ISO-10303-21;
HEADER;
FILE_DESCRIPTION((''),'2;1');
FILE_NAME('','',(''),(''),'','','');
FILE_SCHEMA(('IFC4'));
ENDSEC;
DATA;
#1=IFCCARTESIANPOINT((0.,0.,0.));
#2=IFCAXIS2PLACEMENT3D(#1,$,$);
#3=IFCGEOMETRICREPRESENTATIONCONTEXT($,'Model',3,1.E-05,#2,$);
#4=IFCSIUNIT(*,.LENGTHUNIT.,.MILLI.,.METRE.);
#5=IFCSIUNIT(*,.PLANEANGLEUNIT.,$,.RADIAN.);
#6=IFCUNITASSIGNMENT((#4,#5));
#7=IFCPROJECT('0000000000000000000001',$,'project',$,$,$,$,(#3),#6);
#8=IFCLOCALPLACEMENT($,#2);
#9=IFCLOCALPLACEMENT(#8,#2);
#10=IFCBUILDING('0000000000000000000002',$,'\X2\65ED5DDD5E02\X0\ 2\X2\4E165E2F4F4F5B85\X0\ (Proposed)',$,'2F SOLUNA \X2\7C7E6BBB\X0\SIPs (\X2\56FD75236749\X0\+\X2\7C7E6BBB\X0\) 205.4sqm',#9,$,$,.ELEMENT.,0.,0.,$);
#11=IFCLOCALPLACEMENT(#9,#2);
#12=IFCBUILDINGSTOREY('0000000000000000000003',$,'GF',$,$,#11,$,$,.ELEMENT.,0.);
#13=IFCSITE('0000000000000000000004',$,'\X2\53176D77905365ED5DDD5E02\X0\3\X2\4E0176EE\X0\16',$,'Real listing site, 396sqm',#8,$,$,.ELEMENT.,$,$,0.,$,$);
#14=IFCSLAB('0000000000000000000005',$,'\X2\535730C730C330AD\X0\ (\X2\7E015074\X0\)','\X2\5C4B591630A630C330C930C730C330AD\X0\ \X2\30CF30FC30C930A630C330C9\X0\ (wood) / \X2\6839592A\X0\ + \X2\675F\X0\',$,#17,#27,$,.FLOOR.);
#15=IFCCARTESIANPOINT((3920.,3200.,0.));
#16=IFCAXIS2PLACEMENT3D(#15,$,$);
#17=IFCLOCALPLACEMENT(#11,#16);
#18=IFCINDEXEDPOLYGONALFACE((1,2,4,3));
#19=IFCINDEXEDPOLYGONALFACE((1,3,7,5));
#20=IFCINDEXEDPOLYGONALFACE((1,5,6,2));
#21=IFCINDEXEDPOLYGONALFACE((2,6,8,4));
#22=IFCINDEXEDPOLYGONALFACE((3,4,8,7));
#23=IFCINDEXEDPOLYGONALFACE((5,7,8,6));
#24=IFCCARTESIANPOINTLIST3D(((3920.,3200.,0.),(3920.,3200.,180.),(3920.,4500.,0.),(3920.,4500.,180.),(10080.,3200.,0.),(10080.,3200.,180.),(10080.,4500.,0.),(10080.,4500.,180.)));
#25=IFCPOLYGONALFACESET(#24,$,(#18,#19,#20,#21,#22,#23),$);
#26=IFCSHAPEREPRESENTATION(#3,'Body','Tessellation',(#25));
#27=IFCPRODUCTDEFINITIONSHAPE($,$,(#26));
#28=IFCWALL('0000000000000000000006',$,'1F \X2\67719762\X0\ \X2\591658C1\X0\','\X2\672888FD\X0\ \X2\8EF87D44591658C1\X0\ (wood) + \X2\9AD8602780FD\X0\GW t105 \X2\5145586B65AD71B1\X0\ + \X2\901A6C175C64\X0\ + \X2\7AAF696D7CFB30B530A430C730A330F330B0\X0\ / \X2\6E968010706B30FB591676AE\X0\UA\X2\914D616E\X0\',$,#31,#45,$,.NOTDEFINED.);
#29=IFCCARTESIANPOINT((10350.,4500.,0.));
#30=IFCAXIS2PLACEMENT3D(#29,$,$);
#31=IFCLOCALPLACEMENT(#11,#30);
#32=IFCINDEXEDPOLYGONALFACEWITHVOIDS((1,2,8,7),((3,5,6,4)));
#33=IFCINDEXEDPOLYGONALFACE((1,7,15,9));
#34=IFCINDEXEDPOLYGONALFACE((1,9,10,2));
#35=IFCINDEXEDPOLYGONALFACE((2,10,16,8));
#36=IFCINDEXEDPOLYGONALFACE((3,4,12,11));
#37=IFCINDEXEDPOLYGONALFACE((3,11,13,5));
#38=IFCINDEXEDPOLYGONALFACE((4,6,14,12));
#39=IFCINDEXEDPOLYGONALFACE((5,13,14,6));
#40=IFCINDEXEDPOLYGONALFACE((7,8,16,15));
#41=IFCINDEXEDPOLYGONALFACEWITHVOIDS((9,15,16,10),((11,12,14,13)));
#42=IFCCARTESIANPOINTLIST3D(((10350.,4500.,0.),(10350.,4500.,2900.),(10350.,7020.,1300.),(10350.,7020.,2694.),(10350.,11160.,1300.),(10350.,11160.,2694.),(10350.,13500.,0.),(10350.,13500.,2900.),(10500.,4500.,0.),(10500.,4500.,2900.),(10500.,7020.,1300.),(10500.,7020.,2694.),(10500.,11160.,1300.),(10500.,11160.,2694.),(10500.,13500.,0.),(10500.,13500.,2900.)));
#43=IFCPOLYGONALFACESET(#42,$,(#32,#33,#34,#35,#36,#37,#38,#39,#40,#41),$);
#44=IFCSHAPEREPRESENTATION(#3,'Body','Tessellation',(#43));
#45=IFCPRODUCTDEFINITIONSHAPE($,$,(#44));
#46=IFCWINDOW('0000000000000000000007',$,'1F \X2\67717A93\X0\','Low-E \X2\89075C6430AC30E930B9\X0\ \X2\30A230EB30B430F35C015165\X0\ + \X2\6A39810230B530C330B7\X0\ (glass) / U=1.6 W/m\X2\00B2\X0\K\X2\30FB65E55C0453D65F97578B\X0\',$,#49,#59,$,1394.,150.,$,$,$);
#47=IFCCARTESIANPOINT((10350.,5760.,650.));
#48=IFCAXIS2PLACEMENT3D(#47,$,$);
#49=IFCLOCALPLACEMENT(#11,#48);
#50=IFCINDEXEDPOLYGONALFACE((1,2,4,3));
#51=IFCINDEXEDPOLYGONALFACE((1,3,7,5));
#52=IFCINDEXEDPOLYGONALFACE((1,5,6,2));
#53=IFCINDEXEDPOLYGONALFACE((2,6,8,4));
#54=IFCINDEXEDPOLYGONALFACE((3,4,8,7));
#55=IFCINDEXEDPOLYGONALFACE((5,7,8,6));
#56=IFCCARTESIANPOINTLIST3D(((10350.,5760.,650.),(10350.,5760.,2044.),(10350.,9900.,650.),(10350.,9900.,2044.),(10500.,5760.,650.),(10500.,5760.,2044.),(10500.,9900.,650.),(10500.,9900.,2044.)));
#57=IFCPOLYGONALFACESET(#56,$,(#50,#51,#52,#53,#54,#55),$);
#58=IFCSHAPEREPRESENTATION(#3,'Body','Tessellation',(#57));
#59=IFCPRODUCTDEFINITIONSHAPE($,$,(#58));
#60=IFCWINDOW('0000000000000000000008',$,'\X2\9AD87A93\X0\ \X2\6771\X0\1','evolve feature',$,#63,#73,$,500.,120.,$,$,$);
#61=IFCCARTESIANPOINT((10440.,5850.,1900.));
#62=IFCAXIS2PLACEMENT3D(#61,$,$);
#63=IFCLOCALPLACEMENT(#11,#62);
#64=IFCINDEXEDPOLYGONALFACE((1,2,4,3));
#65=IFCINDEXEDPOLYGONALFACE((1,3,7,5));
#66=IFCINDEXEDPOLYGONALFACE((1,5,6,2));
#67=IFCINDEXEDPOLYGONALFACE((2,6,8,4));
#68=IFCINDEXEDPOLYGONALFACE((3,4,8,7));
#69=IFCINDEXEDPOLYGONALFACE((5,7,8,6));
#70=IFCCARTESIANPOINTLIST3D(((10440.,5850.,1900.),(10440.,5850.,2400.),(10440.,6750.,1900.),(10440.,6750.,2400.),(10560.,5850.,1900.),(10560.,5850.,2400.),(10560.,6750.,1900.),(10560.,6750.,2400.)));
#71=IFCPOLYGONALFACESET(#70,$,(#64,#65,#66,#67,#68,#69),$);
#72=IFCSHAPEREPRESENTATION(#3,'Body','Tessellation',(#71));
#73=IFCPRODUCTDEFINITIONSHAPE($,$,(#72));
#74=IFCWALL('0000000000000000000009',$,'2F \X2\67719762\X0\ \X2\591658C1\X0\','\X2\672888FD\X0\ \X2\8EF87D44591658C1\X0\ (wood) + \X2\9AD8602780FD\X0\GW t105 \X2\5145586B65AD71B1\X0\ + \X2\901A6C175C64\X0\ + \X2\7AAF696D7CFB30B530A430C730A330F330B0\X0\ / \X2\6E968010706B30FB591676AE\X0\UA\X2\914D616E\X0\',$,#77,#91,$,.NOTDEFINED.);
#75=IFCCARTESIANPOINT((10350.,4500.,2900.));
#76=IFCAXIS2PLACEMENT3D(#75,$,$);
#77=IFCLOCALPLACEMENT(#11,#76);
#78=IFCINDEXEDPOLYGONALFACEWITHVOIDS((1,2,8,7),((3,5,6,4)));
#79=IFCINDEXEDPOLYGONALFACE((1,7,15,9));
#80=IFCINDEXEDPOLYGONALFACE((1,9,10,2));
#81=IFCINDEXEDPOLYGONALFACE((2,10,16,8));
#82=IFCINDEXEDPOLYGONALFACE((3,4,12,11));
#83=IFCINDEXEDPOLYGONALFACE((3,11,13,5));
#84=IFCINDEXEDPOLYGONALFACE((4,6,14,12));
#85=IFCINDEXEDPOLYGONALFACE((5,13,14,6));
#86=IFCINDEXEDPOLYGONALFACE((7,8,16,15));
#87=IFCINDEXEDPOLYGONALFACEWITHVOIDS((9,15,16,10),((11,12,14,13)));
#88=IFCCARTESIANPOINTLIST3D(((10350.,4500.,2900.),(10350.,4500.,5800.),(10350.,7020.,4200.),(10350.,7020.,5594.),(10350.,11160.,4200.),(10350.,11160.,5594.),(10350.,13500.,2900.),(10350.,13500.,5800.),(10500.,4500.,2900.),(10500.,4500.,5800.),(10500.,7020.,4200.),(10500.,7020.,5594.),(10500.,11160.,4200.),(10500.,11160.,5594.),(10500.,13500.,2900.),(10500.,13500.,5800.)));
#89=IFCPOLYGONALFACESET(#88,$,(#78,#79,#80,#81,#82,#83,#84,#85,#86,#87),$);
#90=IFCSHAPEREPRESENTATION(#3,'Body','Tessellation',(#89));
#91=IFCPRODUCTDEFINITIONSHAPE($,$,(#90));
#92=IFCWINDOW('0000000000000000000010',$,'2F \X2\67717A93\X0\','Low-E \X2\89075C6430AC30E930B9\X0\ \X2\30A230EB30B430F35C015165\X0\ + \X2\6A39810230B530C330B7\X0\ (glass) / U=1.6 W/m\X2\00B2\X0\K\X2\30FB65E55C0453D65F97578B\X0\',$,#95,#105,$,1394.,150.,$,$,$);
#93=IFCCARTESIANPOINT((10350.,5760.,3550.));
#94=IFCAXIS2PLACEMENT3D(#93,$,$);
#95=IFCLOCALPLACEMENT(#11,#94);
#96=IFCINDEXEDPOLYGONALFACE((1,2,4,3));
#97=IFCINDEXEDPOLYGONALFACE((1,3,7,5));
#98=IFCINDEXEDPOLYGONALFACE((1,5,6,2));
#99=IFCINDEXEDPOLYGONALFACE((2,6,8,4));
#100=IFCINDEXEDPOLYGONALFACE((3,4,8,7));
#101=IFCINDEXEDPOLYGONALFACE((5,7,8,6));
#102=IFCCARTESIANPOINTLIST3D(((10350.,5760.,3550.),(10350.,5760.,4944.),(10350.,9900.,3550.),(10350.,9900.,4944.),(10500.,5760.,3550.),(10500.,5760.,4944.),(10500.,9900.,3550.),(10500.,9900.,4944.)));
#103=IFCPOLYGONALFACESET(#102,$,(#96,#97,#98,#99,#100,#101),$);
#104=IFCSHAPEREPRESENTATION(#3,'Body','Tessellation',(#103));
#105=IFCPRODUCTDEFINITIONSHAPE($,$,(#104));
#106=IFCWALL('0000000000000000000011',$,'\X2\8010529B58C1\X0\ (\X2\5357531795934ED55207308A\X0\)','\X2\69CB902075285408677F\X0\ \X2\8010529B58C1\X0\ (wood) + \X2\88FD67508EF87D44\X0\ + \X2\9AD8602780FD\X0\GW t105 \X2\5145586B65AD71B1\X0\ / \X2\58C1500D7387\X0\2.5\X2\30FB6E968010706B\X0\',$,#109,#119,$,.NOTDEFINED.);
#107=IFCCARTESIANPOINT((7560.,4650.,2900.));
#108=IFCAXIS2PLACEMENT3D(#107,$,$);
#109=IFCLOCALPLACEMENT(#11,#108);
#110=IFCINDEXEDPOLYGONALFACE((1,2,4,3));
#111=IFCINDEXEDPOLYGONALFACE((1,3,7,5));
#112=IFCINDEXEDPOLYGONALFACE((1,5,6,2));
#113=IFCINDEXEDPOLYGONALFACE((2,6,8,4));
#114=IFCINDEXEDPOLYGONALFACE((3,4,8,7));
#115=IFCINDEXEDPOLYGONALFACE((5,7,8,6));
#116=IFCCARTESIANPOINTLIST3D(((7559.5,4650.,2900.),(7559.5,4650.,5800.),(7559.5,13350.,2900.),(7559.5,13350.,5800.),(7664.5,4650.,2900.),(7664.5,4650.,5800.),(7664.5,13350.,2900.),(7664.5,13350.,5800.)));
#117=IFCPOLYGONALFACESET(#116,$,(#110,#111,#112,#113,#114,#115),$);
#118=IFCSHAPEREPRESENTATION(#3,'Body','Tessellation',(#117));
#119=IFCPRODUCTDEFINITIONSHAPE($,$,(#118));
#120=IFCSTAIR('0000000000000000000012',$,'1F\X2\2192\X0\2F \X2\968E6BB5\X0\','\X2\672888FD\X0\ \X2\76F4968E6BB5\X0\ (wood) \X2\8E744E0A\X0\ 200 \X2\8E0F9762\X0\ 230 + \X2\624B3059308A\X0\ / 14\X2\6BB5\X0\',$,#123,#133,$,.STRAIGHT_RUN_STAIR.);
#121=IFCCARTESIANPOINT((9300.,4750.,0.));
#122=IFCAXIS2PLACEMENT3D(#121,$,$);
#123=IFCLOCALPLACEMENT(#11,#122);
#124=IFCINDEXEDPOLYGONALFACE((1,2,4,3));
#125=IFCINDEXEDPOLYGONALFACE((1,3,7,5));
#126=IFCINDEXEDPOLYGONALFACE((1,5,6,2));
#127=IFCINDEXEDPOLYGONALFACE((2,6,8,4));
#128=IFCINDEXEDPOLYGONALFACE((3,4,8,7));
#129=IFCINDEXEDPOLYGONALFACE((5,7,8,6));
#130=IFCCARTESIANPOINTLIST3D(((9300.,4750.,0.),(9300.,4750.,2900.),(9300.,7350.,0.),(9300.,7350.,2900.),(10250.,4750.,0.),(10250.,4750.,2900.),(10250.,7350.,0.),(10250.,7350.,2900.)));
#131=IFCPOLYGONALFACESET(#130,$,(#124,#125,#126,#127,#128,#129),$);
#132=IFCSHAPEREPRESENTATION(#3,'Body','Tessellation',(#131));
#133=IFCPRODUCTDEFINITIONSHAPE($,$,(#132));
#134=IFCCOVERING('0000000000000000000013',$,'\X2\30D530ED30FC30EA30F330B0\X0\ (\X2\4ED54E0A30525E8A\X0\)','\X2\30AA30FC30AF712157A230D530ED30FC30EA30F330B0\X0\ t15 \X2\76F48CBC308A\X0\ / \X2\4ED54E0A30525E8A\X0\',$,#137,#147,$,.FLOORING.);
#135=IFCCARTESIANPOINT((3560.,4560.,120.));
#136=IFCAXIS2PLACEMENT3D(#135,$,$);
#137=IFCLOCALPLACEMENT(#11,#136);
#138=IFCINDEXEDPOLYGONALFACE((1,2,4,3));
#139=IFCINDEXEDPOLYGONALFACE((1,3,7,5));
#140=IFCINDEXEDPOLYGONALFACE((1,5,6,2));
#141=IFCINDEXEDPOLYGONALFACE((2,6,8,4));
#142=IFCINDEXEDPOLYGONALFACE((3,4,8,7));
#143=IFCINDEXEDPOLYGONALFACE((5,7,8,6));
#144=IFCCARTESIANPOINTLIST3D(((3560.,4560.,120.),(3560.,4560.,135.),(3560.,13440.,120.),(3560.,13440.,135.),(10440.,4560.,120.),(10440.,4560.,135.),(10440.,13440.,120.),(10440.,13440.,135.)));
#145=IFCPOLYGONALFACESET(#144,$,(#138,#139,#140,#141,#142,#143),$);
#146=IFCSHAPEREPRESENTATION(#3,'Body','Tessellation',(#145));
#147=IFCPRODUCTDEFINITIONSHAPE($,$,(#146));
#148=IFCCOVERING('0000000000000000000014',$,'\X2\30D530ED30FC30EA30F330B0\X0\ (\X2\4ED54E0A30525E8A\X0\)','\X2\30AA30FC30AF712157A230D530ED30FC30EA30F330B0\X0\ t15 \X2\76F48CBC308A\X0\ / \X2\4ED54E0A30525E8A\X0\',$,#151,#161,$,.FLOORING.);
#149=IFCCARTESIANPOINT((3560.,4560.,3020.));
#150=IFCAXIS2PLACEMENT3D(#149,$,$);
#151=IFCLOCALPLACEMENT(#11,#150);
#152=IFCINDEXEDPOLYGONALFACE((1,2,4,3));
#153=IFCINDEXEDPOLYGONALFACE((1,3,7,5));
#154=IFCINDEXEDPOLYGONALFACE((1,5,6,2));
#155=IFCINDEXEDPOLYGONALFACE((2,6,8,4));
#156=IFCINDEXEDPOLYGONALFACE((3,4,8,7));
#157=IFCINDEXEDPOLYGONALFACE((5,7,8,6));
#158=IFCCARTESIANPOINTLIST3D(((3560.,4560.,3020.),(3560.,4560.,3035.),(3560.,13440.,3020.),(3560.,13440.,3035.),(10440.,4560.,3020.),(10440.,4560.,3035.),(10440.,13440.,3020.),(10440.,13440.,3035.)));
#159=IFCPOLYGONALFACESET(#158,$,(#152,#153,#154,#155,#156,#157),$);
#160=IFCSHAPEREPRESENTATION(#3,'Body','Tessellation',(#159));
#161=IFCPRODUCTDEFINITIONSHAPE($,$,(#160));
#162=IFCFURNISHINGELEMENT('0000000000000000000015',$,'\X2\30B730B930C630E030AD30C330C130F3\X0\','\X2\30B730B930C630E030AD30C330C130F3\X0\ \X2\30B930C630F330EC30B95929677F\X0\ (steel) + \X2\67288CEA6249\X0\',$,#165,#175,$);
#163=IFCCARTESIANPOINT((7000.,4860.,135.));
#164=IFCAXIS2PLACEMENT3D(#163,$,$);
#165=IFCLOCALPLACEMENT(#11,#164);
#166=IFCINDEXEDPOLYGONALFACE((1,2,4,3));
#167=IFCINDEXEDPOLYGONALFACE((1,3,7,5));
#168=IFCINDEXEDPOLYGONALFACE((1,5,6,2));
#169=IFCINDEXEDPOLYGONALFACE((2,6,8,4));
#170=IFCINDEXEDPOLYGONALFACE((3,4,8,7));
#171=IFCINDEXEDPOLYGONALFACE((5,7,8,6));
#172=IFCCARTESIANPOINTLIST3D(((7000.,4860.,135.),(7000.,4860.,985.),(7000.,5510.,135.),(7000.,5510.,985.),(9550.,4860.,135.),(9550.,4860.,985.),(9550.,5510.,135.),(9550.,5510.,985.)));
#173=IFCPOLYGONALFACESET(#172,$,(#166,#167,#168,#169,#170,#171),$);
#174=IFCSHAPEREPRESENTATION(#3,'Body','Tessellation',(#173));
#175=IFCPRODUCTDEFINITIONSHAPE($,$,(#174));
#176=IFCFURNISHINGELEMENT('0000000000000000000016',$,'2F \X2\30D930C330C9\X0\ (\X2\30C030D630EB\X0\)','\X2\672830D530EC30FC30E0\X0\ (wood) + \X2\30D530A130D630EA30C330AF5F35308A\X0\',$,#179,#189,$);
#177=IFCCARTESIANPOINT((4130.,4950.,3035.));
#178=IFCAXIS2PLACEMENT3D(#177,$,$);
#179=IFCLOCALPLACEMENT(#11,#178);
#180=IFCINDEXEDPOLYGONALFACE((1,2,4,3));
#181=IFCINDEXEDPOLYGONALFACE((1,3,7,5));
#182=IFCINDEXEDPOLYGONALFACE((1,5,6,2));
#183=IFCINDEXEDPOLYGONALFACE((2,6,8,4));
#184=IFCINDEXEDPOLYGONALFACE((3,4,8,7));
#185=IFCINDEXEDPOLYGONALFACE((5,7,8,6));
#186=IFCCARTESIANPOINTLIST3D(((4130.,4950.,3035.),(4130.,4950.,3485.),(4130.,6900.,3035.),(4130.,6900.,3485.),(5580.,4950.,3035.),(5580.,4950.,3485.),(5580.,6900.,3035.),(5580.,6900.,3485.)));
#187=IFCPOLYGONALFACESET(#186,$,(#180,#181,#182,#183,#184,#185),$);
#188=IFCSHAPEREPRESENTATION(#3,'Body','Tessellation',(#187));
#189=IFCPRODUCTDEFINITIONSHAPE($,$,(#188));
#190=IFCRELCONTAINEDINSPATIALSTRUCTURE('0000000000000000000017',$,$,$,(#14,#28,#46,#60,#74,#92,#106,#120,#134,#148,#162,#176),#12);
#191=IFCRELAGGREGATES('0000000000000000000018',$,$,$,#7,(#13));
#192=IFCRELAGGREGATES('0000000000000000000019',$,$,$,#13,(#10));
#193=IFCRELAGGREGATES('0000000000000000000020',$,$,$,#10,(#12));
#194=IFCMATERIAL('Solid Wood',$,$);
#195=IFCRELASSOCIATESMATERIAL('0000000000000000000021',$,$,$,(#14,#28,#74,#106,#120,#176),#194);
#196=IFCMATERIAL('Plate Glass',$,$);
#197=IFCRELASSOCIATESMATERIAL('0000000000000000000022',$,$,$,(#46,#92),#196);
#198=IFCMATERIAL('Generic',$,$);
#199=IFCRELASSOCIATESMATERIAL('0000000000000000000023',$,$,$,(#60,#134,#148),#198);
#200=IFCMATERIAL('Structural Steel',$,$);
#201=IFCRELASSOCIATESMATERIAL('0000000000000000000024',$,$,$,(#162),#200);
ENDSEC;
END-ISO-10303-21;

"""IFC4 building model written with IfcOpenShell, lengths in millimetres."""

from ifc_helpers import new_model, si_unit, frame, frame_2d, origin, place, context, project, spatial, rectangle, extrude, material, element, fill, save


model = new_model("IFC4")

# Units and contexts
model_context = context("Model", 3, precision=1e-05, world=origin())
ifc_project = project(units=[si_unit("LENGTHUNIT", "METRE", prefix="MILLI"), si_unit("PLANEANGLEUNIT", "RADIAN")], contexts=[model_context])

# Site, building, storey
site_placement = place(None, origin())
site = spatial("IfcSite", under=ifc_project, at=site_placement, Name="北海道旭川市3丁目16", ObjectType="Real listing site, 396sqm", CompositionType="ELEMENT", RefElevation=0.0)
building_placement = place(site_placement, origin())
building = spatial("IfcBuilding", under=site, at=building_placement, Name="旭川市 2世帯住宅 (Proposed)", ObjectType="2F SOLUNA 籾殻SIPs (国産杉+籾殻) 205.4sqm", CompositionType="ELEMENT", ElevationOfRefHeight=0.0, ElevationOfTerrain=0.0)
storey_placement = place(building_placement, origin())
storey = spatial("IfcBuildingStorey", under=building, at=storey_placement, Name="GF", CompositionType="ELEMENT", Elevation=0.0)

# Slab
ifc_material_1 = material(Name="Solid Wood")
slab_placement = place(storey_placement, frame((3920.0, 3200.0, 0.0)))
element("IfcSlab", 1, at=slab_placement, inside=storey, material=ifc_material_1, Name="南デッキ (縁側)", Description="屋外ウッドデッキ ハードウッド (wood) / 根太 + 束", PredefinedType="FLOOR", context=model_context, shape_type="SweptSolid", body=[
    extrude(rectangle(XDim=6160.0, YDim=1300.0, at=frame_2d((3080.0, 650.0))), frame((3920.0, 3200.0, 0.0)), (0.0, 0.0, 1.0), 180.0),
])

# Wall, openings, windows
wall_1_placement = place(storey_placement, frame((10350.0, 4500.0, 0.0)))
wall_1 = element("IfcWall", 2, at=wall_1_placement, inside=storey, material=ifc_material_1, Name="1F 東面 外壁", Description="木製 軸組外壁 (wood) + 高性能GW t105 充填断熱 + 通気層 + 窯業系サイディング / 準耐火・外皮UA配慮", PredefinedType="NOTDEFINED", context=model_context, shape_type="SweptSolid", body=[
    extrude(rectangle(XDim=150.0, YDim=9000.0, at=frame_2d((75.0, 4500.0))), frame((10350.0, 4500.0, 0.0)), (0.0, 0.0, 1.0), 2900.0),
])
opening_1_placement = place(storey_placement, frame((10350.0, 5760.0, 650.0)))
opening_1 = element("IfcOpeningElement", 3, at=opening_1_placement, cuts=wall_1, PredefinedType="NOTDEFINED", context=model_context, shape_type="SweptSolid", body=[
    extrude(rectangle(XDim=150.0, YDim=4140.0, at=frame_2d((75.0, 2070.0))), frame((10350.0, 5760.0, 650.0)), (0.0, 0.0, 1.0), 1394.0),
])
opening_2_placement = place(storey_placement, frame((10440.0, 5850.0, 1900.0)))
opening_2 = element("IfcOpeningElement", 4, at=opening_2_placement, cuts=wall_1, PredefinedType="NOTDEFINED", context=model_context, shape_type="SweptSolid", body=[
    extrude(rectangle(XDim=120.0, YDim=900.0, at=frame_2d((60.0, 450.0))), frame((10440.0, 5850.0, 1900.0)), (0.0, 0.0, 1.0), 500.0),
])
ifc_material_2 = material(Name="Plate Glass")
window_1_placement = place(storey_placement, frame((10350.0, 5760.0, 650.0)))
window_1 = element("IfcWindow", 5, at=window_1_placement, inside=storey, material=ifc_material_2, Name="1F 東窓", Description="Low-E 複層ガラス アルゴン封入 + 樹脂サッシ (glass) / U=1.6 W/m²K・日射取得型", OverallHeight=1394.0, OverallWidth=150.0, context=model_context, shape_type="SweptSolid", body=[
    extrude(rectangle(XDim=150.0, YDim=4140.0, at=frame_2d((75.0, 2070.0))), frame((10350.0, 5760.0, 650.0)), (0.0, 0.0, 1.0), 1394.0),
])
fill(opening_1, window_1)
ifc_material_3 = material(Name="Generic")
window_2_placement = place(storey_placement, frame((10440.0, 5850.0, 1900.0)))
window_2 = element("IfcWindow", 6, at=window_2_placement, inside=storey, material=ifc_material_3, Name="高窓 東1", Description="evolve feature", OverallHeight=500.0, OverallWidth=120.0, context=model_context, shape_type="SweptSolid", body=[
    extrude(rectangle(XDim=120.0, YDim=900.0, at=frame_2d((60.0, 450.0))), frame((10440.0, 5850.0, 1900.0)), (0.0, 0.0, 1.0), 500.0),
])
fill(opening_2, window_2)

# Wall, opening, window
wall_2_placement = place(storey_placement, frame((10350.0, 4500.0, 2900.0)))
wall_2 = element("IfcWall", 7, at=wall_2_placement, inside=storey, material=ifc_material_1, Name="2F 東面 外壁", Description="木製 軸組外壁 (wood) + 高性能GW t105 充填断熱 + 通気層 + 窯業系サイディング / 準耐火・外皮UA配慮", PredefinedType="NOTDEFINED", context=model_context, shape_type="SweptSolid", body=[
    extrude(rectangle(XDim=150.0, YDim=9000.0, at=frame_2d((75.0, 4500.0))), frame((10350.0, 4500.0, 2900.0)), (0.0, 0.0, 1.0), 2900.0),
])
opening_3_placement = place(storey_placement, frame((10350.0, 5760.0, 3550.0)))
opening_3 = element("IfcOpeningElement", 8, at=opening_3_placement, cuts=wall_2, PredefinedType="NOTDEFINED", context=model_context, shape_type="SweptSolid", body=[
    extrude(rectangle(XDim=150.0, YDim=4140.0, at=frame_2d((75.0, 2070.0))), frame((10350.0, 5760.0, 3550.0)), (0.0, 0.0, 1.0), 1394.0),
])
window_3_placement = place(storey_placement, frame((10350.0, 5760.0, 3550.0)))
window_3 = element("IfcWindow", 9, at=window_3_placement, inside=storey, material=ifc_material_2, Name="2F 東窓", Description="Low-E 複層ガラス アルゴン封入 + 樹脂サッシ (glass) / U=1.6 W/m²K・日射取得型", OverallHeight=1394.0, OverallWidth=150.0, context=model_context, shape_type="SweptSolid", body=[
    extrude(rectangle(XDim=150.0, YDim=4140.0, at=frame_2d((75.0, 2070.0))), frame((10350.0, 5760.0, 3550.0)), (0.0, 0.0, 1.0), 1394.0),
])
fill(opening_3, window_3)

# Wall
wall_3_placement = place(storey_placement, frame((7560.0, 4650.0, 2900.0)))
element("IfcWall", 10, at=wall_3_placement, inside=storey, material=ifc_material_1, Name="耐力壁 (南北間仕切り)", Description="構造用合板 耐力壁 (wood) + 製材軸組 + 高性能GW t105 充填断熱 / 壁倍率2.5・準耐火", PredefinedType="NOTDEFINED", context=model_context, shape_type="SweptSolid", body=[
    extrude(rectangle(XDim=105.0, YDim=8700.0, at=frame_2d((52.0, 4350.0))), frame((7560.0, 4650.0, 2900.0)), (0.0, 0.0, 1.0), 2900.0),
])

# Stair
stair_placement = place(storey_placement, frame((9300.0, 4750.0, 0.0)))
element("IfcStair", 11, at=stair_placement, inside=storey, material=ifc_material_1, Name="1F→2F 階段", Description="木製 直階段 (wood) 蹴上 200 踏面 230 + 手すり / 14段", PredefinedType="STRAIGHT_RUN_STAIR", context=model_context, shape_type="SweptSolid", body=[
    extrude(rectangle(XDim=950.0, YDim=2600.0, at=frame_2d((475.0, 1300.0))), frame((9300.0, 4750.0, 0.0)), (0.0, 0.0, 1.0), 2900.0),
])

# Coverings
covering_1_placement = place(storey_placement, frame((3560.0, 4560.0, 120.0)))
element("IfcCovering", 12, at=covering_1_placement, inside=storey, material=ifc_material_3, Name="フローリング (仕上げ床)", Description="オーク無垢フローリング t15 直貼り / 仕上げ床", PredefinedType="FLOORING", context=model_context, shape_type="SweptSolid", body=[
    extrude(rectangle(XDim=6880.0, YDim=8880.0, at=frame_2d((3440.0, 4440.0))), frame((3560.0, 4560.0, 120.0)), (0.0, 0.0, 1.0), 15.0),
])
covering_2_placement = place(storey_placement, frame((3560.0, 4560.0, 3020.0)))
element("IfcCovering", 13, at=covering_2_placement, inside=storey, material=ifc_material_3, Name="フローリング (仕上げ床)", Description="オーク無垢フローリング t15 直貼り / 仕上げ床", PredefinedType="FLOORING", context=model_context, shape_type="SweptSolid", body=[
    extrude(rectangle(XDim=6880.0, YDim=8880.0, at=frame_2d((3440.0, 4440.0))), frame((3560.0, 4560.0, 3020.0)), (0.0, 0.0, 1.0), 15.0),
])

# Furnishing elements
ifc_material_4 = material(Name="Structural Steel")
furnishing_1_placement = place(storey_placement, frame((7000.0, 4860.0, 135.0)))
element("IfcFurnishingElement", 14, at=furnishing_1_placement, inside=storey, material=ifc_material_4, Name="システムキッチン", Description="システムキッチン ステンレス天板 (steel) + 木質扉", context=model_context, shape_type="SweptSolid", body=[
    extrude(rectangle(XDim=2550.0, YDim=650.0, at=frame_2d((1275.0, 325.0))), frame((7000.0, 4860.0, 135.0)), (0.0, 0.0, 1.0), 850.0),
])
furnishing_2_placement = place(storey_placement, frame((4130.0, 4950.0, 3035.0)))
element("IfcFurnishingElement", 15, at=furnishing_2_placement, inside=storey, material=ifc_material_1, Name="2F ベッド (ダブル)", Description="木フレーム (wood) + ファブリック張り", context=model_context, shape_type="SweptSolid", body=[
    extrude(rectangle(XDim=1450.0, YDim=1950.0, at=frame_2d((725.0, 975.0))), frame((4130.0, 4950.0, 3035.0)), (0.0, 0.0, 1.0), 450.0),
])

save(model, "model.ifc")
